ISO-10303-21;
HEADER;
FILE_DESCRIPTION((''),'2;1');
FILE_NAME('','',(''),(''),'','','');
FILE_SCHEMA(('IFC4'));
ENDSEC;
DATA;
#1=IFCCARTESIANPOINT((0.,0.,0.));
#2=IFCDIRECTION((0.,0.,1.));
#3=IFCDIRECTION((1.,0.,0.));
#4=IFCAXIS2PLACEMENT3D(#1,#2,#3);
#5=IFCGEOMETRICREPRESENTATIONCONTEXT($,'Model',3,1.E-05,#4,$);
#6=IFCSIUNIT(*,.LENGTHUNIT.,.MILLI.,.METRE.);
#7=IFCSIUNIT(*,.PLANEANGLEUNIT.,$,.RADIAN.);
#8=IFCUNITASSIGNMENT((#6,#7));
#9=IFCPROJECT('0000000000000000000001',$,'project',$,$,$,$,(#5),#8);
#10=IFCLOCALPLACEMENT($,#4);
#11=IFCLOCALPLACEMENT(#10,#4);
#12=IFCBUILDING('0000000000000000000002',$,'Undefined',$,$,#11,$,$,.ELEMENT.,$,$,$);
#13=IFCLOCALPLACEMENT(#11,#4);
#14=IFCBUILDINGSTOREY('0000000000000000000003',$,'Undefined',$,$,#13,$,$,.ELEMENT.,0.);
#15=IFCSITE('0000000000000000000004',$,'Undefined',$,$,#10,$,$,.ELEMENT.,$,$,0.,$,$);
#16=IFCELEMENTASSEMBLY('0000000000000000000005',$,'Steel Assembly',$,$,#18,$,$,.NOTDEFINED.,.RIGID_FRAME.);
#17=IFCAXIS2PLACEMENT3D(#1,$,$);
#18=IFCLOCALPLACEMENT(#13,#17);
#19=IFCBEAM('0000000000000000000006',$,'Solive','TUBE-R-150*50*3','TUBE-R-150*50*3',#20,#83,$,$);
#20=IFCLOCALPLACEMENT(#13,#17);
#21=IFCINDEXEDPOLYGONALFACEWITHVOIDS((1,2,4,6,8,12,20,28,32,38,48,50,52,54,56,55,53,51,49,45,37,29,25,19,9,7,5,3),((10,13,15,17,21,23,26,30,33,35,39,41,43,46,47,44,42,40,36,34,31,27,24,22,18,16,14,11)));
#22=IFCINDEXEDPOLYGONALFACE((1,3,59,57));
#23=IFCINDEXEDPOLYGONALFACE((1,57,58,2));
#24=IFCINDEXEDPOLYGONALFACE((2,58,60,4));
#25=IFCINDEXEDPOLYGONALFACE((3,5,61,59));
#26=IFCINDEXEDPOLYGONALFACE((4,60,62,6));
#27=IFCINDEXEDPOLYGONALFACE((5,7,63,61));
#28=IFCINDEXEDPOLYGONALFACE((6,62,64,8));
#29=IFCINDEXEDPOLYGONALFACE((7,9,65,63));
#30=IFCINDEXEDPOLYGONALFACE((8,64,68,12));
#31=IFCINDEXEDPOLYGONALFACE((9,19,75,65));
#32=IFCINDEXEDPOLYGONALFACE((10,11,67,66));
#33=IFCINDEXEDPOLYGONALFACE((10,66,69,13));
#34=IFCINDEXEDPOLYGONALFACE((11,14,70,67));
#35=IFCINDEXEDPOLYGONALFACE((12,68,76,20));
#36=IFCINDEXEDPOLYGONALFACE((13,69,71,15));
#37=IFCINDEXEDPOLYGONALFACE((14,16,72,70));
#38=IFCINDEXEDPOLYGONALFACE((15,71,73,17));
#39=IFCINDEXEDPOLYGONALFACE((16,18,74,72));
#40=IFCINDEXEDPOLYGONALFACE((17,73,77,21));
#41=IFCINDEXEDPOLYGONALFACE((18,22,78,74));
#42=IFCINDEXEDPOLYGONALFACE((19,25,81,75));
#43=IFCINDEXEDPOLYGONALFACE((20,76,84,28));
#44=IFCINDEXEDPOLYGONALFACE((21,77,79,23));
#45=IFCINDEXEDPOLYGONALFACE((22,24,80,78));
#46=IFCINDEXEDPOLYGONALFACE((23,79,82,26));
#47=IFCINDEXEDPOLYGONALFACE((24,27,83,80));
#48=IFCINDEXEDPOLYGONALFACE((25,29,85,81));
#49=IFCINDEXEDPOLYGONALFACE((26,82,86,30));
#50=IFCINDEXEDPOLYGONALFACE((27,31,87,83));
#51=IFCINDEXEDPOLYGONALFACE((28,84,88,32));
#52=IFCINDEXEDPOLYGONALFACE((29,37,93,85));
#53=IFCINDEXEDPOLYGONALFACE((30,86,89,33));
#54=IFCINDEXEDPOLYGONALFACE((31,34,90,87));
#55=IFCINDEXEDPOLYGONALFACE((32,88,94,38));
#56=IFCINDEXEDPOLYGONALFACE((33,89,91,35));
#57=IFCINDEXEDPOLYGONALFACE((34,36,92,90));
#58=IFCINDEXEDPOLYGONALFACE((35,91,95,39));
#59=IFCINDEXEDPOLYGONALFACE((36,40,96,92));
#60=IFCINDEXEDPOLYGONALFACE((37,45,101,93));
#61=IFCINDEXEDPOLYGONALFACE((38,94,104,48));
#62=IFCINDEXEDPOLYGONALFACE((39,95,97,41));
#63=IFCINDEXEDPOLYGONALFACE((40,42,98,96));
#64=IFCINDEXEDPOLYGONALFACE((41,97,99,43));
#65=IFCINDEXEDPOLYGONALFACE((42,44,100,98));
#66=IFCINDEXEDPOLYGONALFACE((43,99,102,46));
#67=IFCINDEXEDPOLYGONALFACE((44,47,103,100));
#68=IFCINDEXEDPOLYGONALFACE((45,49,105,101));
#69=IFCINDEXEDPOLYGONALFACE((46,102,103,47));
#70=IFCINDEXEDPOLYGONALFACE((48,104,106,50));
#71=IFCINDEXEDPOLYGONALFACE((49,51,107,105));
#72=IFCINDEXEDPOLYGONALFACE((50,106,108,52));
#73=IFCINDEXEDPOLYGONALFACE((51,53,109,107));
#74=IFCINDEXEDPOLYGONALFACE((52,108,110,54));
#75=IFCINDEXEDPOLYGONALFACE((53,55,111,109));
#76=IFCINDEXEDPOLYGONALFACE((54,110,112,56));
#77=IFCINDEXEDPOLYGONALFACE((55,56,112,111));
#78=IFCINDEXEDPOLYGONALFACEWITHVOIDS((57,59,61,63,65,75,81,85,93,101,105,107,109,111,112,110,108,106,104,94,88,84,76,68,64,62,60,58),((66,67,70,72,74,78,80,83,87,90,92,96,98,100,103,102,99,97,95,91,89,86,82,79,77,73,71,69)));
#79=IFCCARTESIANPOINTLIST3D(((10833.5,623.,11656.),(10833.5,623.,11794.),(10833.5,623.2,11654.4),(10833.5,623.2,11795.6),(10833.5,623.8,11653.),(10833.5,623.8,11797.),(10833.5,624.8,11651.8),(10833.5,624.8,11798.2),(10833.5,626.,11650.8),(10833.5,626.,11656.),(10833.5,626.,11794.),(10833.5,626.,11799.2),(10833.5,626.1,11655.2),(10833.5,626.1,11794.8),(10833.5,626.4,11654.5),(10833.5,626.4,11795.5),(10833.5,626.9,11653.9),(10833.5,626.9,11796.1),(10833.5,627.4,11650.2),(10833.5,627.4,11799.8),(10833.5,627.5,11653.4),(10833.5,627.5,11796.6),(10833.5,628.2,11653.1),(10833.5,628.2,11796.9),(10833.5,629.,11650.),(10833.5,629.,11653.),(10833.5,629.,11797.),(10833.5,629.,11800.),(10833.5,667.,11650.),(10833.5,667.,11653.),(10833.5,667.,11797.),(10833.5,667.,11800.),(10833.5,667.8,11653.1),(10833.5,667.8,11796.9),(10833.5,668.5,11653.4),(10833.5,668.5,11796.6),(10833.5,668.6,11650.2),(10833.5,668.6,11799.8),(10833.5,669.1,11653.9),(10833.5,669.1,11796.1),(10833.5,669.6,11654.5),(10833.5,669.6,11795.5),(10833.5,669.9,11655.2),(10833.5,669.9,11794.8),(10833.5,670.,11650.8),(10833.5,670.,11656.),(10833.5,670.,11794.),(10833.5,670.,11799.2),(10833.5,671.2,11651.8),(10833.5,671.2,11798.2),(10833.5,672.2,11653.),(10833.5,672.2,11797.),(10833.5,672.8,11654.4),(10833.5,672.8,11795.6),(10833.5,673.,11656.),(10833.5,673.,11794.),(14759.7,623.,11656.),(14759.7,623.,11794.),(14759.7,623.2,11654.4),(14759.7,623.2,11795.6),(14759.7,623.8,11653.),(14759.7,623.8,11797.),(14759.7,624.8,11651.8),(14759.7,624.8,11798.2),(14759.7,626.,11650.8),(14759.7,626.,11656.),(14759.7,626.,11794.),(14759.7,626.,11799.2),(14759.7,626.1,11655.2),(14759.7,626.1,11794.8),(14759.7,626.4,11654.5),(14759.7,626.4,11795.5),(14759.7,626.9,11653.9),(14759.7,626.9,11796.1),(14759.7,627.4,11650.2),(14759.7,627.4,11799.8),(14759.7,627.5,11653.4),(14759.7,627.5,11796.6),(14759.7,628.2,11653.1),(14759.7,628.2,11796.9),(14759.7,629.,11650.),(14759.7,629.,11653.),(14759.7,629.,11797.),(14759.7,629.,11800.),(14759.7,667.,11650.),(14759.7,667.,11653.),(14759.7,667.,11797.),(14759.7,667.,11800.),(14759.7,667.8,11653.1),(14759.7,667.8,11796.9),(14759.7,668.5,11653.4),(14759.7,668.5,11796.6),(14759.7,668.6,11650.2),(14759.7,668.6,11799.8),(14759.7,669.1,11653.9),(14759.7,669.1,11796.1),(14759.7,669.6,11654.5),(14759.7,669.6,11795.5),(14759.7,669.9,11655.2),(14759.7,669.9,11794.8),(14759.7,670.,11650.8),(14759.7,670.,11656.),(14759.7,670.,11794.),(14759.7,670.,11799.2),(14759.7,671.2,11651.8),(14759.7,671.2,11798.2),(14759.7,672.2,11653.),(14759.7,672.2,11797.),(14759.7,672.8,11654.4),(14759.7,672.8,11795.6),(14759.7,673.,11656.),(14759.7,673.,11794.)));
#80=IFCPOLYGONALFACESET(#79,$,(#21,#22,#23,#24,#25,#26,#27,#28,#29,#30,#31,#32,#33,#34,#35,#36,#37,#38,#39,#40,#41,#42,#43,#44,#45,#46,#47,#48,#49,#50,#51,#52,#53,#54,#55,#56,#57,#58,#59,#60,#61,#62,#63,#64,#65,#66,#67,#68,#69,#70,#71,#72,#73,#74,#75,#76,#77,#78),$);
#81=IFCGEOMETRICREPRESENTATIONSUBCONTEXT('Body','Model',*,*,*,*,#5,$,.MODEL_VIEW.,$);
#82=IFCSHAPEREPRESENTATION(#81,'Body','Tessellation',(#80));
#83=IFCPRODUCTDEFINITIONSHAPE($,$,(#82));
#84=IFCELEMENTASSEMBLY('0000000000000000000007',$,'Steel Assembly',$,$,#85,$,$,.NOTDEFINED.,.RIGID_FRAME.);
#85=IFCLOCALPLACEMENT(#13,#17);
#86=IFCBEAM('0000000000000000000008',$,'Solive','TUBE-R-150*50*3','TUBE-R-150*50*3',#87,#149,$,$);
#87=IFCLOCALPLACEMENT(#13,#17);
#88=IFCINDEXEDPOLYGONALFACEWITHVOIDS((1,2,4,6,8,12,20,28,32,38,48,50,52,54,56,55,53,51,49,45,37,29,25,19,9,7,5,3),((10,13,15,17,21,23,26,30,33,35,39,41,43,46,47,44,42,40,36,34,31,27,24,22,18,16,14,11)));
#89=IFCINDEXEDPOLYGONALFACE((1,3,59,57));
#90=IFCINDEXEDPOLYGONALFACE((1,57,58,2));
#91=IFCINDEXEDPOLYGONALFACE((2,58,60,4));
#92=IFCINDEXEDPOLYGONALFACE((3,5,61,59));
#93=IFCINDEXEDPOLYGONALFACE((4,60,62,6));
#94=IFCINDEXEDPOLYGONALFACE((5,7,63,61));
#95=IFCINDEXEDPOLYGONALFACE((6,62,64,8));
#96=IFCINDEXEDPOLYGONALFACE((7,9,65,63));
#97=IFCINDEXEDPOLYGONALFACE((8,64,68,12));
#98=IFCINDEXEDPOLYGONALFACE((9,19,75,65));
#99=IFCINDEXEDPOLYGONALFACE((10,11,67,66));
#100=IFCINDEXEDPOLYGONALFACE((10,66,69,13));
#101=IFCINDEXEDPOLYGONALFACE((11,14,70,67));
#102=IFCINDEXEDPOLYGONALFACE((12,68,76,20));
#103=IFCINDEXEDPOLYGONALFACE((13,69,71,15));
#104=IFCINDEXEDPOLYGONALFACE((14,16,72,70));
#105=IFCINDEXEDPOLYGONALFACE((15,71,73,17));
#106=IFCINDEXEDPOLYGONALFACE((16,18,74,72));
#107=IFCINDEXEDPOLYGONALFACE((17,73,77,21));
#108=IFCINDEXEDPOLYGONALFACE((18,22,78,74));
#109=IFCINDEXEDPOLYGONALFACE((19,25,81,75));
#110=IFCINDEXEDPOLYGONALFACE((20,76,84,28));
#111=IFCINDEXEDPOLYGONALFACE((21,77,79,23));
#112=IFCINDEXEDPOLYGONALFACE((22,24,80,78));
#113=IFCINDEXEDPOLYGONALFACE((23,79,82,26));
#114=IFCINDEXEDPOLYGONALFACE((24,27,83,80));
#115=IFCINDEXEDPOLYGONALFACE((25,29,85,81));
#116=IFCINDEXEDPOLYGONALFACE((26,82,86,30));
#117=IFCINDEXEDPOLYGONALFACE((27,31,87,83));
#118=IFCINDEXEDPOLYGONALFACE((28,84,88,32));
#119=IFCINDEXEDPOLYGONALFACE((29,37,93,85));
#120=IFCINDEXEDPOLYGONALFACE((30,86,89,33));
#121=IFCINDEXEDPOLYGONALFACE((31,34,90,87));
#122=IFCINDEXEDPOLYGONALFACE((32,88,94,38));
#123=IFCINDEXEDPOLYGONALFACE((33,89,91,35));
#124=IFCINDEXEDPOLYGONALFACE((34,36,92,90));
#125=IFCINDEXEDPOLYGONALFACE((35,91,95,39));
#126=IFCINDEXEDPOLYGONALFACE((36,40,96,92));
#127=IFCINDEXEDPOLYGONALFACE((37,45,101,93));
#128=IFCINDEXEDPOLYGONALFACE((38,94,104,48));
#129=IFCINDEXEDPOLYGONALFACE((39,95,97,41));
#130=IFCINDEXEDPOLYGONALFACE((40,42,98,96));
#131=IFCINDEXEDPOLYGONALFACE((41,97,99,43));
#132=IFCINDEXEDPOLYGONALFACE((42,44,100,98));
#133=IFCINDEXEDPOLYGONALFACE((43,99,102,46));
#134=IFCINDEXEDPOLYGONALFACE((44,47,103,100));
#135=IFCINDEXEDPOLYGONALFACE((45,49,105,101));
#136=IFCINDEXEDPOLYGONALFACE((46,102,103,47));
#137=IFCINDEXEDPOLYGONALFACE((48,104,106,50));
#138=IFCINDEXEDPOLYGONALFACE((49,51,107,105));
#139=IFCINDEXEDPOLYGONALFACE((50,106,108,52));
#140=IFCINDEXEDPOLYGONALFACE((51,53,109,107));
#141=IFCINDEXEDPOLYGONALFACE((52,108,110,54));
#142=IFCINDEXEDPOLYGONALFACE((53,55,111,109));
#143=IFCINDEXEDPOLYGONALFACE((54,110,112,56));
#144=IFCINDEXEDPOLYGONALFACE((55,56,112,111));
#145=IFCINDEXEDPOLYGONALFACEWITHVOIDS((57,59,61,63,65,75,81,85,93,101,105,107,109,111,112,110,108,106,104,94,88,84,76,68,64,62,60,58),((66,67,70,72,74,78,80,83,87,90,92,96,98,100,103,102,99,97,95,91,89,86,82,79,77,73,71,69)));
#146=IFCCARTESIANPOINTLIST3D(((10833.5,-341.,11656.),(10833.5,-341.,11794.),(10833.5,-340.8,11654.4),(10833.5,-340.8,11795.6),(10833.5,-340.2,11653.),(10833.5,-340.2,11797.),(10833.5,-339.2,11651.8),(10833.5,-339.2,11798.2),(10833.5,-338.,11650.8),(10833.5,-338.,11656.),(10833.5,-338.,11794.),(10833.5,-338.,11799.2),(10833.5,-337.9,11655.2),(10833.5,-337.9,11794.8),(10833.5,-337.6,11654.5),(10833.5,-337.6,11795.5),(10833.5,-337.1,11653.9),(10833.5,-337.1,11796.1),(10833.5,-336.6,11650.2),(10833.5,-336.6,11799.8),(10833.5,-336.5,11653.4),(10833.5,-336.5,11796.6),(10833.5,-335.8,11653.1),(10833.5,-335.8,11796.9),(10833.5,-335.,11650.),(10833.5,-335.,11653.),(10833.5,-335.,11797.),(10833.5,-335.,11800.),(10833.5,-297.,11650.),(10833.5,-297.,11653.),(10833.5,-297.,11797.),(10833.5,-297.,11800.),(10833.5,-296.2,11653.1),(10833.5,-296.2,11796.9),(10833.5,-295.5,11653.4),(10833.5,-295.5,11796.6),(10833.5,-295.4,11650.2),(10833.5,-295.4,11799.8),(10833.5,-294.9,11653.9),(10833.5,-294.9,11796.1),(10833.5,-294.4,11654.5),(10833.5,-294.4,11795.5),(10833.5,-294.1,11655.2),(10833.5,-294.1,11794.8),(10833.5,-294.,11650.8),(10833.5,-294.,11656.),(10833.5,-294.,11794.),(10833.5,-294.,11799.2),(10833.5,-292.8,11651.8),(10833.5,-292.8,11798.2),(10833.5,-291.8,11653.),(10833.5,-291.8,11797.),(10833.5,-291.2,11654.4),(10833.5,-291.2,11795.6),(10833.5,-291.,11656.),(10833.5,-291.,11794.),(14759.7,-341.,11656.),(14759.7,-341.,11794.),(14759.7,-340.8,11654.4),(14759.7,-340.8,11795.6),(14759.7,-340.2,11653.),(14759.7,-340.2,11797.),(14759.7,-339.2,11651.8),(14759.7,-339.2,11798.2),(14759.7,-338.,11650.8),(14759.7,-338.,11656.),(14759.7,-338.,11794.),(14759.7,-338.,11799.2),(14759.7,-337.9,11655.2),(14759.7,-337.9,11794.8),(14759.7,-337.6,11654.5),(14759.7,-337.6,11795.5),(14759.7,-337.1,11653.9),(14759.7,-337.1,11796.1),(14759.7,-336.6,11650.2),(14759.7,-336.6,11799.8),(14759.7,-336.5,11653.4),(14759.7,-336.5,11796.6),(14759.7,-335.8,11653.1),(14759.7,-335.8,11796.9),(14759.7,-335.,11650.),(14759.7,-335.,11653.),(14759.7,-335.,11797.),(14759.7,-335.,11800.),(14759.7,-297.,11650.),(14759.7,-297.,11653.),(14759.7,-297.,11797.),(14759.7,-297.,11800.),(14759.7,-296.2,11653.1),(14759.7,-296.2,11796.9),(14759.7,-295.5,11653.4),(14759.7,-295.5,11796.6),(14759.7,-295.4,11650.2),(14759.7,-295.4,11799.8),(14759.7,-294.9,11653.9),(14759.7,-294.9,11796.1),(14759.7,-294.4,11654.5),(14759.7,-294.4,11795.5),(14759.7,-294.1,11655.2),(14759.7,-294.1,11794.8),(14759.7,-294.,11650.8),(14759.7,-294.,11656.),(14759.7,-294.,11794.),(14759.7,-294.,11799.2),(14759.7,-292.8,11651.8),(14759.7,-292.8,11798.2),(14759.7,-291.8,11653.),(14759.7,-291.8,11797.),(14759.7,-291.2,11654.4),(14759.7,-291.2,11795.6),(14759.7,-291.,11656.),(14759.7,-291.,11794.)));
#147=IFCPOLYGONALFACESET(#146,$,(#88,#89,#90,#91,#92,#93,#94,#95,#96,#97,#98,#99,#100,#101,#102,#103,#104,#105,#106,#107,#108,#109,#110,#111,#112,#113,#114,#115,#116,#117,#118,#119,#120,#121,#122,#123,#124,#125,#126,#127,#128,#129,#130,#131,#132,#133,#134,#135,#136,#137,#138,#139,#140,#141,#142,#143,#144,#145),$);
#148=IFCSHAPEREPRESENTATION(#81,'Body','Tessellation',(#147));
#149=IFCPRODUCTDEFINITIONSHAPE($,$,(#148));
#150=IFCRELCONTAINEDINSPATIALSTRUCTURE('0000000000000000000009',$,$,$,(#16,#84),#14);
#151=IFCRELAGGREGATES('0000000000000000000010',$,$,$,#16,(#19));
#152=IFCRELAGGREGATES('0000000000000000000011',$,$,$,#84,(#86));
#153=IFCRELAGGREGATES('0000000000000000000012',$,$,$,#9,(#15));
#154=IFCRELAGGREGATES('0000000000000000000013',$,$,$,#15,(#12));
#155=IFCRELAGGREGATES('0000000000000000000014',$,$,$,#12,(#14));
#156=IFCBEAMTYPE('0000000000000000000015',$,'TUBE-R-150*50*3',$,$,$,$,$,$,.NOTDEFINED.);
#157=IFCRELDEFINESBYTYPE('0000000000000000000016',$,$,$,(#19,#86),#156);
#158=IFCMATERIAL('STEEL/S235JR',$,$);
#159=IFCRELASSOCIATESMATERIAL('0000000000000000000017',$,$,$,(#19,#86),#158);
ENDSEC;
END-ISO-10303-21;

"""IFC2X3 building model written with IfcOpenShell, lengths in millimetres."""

from ifc_helpers import new_model, si_unit, frame, origin_with_axes, origin_2d_with_axis, place, context, subcontext, project, spatial, hollow_rectangle, extrude, material, type_object, element, aggregate, save


model = new_model("IFC2X3")

# Units and contexts
model_context = context("Model", 3, precision=1e-05, world=origin_with_axes())
body_context = subcontext(model_context, "Body", "Model", "MODEL_VIEW")
ifc_project = project(units=[si_unit("LENGTHUNIT", "METRE", prefix="MILLI"), si_unit("PLANEANGLEUNIT", "RADIAN")], contexts=[model_context])

# Site, building, storey
site_placement = place(None, origin_with_axes())
site = spatial("IfcSite", under=ifc_project, at=site_placement, Name="Undefined", CompositionType="ELEMENT", RefElevation=0.0)
building_placement = place(site_placement, origin_with_axes())
building = spatial("IfcBuilding", under=site, at=building_placement, Name="Undefined", CompositionType="ELEMENT")
storey_placement = place(building_placement, origin_with_axes())
storey = spatial("IfcBuildingStorey", under=building, at=storey_placement, Name="Undefined", CompositionType="ELEMENT", Elevation=0.0)

# Element assemblies, beams
ifc_material_1 = material(Name="STEEL/S235JR")
beam_type_1 = type_object("IfcBeamType", Name="TUBE-R-150*50*3", PredefinedType="NOTDEFINED")
assembly_1_placement = place(storey_placement, origin_with_axes())
assembly_1 = element("IfcElementAssembly", 1, at=assembly_1_placement, inside=storey, Name="Steel Assembly", AssemblyPlace="NOTDEFINED", PredefinedType="RIGID_FRAME")
beam_1_placement = place(assembly_1_placement, frame((14759.7, 648.0, 11725.0), z_axis=(0.0, 0.0, 1.0), x_axis=(-1.0, 0.0, 0.0)))
beam_1 = element("IfcBeam", 2, at=beam_1_placement, type_object=beam_type_1, material=ifc_material_1, Name="Solive", Description="TUBE-R-150*50*3", ObjectType="TUBE-R-150*50*3", context=body_context, shape_type="SweptSolid", body=[
    extrude(hollow_rectangle(XDim=50.0, YDim=150.0, WallThickness=3.0, InnerFilletRadius=3.0, OuterFilletRadius=6.0, at=origin_2d_with_axis()), frame((3926.2, 0.0, 0.0), z_axis=(-1.0, 0.0, 0.0), x_axis=(0.0, -1.0, 0.0)), (0.0, 0.0, 1.0), 3926.2),
])
aggregate(assembly_1, [beam_1])
assembly_2_placement = place(storey_placement, origin_with_axes())
assembly_2 = element("IfcElementAssembly", 3, at=assembly_2_placement, inside=storey, Name="Steel Assembly", AssemblyPlace="NOTDEFINED", PredefinedType="RIGID_FRAME")
beam_2_placement = place(assembly_2_placement, frame((14759.7, -316.0, 11725.0), z_axis=(0.0, 0.0, 1.0), x_axis=(-1.0, 0.0, 0.0)))
beam_2 = element("IfcBeam", 4, at=beam_2_placement, type_object=beam_type_1, material=ifc_material_1, Name="Solive", Description="TUBE-R-150*50*3", ObjectType="TUBE-R-150*50*3", context=body_context, shape_type="SweptSolid", body=[
    extrude(hollow_rectangle(XDim=50.0, YDim=150.0, WallThickness=3.0, InnerFilletRadius=3.0, OuterFilletRadius=6.0, at=origin_2d_with_axis()), frame((3926.2, 0.0, 0.0), z_axis=(-1.0, 0.0, 0.0), x_axis=(0.0, -1.0, 0.0)), (0.0, 0.0, 1.0), 3926.2),
])
aggregate(assembly_2, [beam_2])

save(model, "model.ifc")
